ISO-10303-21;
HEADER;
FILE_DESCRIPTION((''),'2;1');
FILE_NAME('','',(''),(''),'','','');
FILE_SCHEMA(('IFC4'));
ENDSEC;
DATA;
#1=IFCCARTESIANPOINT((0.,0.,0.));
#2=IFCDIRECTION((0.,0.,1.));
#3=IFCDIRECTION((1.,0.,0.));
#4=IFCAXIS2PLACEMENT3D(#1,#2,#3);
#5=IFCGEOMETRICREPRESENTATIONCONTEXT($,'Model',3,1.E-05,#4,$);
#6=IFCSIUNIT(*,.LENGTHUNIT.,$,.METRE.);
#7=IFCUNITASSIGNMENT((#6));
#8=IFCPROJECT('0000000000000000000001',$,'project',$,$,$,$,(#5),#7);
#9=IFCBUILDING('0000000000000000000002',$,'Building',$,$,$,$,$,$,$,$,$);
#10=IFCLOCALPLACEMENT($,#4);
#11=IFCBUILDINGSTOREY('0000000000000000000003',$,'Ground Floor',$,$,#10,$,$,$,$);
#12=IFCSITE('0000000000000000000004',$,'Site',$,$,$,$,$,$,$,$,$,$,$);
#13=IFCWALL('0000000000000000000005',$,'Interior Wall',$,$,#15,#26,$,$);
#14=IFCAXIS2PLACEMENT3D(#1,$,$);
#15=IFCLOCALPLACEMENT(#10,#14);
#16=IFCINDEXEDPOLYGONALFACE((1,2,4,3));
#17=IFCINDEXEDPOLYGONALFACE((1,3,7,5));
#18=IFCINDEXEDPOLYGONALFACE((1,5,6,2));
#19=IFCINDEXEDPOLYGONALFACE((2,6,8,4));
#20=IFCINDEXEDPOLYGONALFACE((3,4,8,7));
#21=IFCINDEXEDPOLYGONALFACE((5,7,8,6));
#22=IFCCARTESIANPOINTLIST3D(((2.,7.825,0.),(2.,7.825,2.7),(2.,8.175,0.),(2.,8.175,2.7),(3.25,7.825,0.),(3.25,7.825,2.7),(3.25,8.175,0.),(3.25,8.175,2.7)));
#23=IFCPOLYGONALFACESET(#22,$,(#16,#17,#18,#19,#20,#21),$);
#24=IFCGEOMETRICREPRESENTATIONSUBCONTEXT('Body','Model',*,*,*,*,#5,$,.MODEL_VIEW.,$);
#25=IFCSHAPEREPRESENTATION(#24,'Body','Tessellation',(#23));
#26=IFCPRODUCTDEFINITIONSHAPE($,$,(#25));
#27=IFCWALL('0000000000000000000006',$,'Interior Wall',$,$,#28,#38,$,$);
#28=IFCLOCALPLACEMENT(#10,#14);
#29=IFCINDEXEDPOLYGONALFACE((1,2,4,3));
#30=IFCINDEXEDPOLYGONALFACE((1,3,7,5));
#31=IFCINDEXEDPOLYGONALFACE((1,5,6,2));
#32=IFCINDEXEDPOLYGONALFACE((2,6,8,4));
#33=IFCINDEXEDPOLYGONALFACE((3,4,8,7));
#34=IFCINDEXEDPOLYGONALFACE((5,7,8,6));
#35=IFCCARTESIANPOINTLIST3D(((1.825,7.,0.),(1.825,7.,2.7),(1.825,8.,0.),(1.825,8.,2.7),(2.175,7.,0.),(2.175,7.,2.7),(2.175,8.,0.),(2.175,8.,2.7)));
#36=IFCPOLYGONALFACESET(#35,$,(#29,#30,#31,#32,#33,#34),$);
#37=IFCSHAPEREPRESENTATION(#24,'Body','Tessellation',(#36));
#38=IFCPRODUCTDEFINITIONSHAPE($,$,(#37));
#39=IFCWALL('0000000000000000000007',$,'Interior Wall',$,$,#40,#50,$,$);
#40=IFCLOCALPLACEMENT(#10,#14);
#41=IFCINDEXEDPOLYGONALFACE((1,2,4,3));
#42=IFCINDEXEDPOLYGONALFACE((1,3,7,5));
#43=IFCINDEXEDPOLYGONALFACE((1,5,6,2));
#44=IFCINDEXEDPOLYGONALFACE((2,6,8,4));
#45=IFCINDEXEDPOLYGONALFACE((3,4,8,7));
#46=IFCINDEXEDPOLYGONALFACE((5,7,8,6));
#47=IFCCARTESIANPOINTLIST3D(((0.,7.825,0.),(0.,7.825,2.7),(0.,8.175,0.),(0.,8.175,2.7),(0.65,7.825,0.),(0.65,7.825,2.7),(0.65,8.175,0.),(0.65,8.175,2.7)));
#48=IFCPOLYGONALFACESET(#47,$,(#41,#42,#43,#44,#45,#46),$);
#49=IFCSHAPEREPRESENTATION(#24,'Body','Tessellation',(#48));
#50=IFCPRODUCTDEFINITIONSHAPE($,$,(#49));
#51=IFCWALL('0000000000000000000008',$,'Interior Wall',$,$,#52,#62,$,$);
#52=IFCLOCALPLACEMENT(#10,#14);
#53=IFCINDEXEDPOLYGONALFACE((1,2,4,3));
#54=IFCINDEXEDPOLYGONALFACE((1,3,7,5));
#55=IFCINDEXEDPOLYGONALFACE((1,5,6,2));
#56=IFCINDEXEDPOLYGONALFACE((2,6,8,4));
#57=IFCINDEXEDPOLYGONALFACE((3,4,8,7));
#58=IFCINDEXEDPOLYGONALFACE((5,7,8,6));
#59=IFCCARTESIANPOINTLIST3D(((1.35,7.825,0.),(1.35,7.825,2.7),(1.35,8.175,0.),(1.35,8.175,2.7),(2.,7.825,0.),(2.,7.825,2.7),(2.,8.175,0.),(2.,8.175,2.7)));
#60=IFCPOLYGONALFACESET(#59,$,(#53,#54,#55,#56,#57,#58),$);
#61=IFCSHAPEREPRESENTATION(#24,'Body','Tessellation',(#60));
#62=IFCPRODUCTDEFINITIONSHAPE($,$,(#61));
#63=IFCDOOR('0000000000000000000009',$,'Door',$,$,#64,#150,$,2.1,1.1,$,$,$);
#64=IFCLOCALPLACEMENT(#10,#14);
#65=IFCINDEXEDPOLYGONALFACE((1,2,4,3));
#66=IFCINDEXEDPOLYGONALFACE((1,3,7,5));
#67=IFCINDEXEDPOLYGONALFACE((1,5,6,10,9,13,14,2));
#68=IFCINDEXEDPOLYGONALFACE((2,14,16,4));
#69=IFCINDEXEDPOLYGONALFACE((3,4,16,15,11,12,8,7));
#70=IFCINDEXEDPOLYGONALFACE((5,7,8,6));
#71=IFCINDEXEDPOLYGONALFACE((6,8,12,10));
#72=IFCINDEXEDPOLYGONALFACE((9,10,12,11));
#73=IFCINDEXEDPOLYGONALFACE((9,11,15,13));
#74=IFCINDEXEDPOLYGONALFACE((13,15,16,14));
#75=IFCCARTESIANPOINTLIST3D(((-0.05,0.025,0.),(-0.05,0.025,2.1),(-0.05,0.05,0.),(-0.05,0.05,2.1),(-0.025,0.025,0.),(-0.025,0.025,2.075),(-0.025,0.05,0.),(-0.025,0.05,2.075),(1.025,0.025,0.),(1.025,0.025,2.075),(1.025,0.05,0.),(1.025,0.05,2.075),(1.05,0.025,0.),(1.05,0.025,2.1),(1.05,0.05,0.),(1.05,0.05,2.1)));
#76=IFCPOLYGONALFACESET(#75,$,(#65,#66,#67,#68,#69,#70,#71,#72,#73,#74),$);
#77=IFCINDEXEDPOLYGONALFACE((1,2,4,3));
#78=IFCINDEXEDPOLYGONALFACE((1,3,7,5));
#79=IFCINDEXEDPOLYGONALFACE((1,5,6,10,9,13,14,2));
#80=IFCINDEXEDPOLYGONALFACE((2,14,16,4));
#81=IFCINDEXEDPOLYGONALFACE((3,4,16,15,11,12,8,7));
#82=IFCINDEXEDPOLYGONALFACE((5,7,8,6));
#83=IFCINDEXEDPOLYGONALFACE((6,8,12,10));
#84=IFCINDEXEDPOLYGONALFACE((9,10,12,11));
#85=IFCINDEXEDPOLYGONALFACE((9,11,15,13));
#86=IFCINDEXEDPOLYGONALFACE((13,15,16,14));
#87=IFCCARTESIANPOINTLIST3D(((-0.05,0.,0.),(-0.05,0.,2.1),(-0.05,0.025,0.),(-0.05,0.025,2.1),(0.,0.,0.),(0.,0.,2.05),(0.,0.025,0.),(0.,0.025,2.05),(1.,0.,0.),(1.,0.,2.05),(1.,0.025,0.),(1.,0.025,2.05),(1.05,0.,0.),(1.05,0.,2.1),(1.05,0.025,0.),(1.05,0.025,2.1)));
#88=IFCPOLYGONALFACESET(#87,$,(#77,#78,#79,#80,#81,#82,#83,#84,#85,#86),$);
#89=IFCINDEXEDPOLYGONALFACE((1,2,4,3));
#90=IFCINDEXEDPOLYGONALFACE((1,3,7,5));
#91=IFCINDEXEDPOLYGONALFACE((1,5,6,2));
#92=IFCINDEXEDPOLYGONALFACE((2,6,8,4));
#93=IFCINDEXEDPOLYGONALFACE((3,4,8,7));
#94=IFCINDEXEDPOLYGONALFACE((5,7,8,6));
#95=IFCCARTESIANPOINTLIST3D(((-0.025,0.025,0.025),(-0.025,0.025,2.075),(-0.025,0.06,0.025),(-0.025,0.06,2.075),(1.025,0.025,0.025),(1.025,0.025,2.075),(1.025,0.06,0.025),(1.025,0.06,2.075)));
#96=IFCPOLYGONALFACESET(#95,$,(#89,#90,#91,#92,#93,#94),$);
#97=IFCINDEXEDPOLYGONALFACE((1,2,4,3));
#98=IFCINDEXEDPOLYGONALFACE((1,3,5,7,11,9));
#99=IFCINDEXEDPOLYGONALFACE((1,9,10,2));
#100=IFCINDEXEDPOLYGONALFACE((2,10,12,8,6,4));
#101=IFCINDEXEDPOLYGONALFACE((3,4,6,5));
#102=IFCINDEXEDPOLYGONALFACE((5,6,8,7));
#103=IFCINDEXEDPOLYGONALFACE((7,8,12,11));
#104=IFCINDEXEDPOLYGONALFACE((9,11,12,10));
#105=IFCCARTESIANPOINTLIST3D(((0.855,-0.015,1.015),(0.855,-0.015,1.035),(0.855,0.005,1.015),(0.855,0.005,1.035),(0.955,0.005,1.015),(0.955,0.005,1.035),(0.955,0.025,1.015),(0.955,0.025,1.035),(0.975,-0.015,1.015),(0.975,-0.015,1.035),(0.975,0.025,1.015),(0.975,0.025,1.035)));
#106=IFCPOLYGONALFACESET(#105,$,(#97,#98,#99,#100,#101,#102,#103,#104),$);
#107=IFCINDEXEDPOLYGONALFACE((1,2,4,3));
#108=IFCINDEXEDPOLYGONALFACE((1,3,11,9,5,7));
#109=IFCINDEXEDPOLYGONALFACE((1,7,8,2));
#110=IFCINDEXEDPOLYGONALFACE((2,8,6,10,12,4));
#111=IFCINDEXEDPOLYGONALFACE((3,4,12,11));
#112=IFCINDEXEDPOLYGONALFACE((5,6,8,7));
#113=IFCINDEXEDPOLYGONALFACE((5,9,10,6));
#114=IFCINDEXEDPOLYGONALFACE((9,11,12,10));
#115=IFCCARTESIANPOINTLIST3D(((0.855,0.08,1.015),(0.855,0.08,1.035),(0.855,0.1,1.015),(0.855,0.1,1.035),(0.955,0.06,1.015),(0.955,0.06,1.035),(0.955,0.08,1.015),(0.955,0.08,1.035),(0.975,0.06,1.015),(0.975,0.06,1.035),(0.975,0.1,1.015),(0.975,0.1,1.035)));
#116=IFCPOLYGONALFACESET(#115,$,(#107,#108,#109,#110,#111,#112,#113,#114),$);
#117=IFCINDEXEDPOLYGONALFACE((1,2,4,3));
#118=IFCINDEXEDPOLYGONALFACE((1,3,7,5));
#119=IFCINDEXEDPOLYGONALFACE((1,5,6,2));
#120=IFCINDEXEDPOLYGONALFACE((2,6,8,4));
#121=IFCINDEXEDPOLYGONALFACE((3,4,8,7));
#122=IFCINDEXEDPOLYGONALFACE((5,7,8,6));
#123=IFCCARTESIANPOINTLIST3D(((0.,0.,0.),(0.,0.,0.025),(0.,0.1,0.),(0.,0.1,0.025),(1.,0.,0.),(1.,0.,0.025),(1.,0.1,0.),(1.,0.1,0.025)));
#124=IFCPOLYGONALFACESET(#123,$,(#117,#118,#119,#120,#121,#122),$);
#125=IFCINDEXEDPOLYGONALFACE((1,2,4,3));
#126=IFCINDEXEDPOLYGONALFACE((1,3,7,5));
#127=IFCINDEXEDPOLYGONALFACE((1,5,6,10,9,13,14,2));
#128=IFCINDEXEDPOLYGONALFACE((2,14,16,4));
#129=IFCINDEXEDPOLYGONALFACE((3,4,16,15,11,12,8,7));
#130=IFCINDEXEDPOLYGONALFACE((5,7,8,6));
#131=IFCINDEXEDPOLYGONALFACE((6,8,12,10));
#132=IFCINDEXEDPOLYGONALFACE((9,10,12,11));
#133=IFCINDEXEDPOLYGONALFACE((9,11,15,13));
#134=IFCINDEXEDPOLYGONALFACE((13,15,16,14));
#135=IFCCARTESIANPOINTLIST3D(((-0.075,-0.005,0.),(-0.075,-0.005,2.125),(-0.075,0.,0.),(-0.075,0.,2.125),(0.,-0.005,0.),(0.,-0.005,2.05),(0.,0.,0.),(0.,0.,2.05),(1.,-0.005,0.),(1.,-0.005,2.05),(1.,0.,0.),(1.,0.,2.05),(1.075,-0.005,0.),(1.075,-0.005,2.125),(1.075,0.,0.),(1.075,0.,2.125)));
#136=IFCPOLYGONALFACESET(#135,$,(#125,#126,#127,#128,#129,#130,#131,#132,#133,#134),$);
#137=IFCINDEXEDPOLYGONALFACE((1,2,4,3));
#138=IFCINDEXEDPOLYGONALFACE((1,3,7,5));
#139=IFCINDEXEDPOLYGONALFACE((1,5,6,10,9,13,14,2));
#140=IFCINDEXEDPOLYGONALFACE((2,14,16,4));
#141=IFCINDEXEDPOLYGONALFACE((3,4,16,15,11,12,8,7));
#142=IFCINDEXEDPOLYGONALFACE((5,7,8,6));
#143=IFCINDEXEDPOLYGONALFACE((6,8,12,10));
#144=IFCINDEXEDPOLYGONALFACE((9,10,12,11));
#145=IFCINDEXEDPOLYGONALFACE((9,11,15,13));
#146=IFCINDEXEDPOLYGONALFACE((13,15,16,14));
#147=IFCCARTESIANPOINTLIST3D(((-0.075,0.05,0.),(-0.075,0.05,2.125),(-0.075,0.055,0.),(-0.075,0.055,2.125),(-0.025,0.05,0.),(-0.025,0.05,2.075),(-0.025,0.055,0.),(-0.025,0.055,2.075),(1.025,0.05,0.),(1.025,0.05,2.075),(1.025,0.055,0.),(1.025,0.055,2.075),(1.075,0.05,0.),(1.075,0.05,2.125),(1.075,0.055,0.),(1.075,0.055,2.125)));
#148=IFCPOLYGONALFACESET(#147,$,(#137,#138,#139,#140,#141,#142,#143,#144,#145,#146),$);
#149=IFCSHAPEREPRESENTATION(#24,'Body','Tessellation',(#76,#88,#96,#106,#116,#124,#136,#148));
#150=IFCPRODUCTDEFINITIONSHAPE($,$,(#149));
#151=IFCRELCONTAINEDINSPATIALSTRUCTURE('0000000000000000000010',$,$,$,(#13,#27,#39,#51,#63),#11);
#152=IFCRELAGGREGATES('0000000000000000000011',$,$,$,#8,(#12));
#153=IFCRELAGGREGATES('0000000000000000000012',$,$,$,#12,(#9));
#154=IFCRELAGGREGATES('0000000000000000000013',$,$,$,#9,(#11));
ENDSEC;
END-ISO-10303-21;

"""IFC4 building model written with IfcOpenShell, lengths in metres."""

from ifc_helpers import new_model, si_unit, frame, origin_with_axes, place, context, subcontext, project, spatial, line, indexed_curve, outline, extrude, element, save


model = new_model("IFC4")

# Units and contexts
model_context = context("Model", 3, precision=1e-05, world=origin_with_axes())
body_context = subcontext(model_context, "Body", "Model", "MODEL_VIEW")
ifc_project = project(units=[si_unit("LENGTHUNIT", "METRE")], contexts=[model_context])

# Site, building, storey
site = spatial("IfcSite", under=ifc_project, Name="Site")
building = spatial("IfcBuilding", under=site, Name="Building")
storey_placement = place(None, origin_with_axes())
storey = spatial("IfcBuildingStorey", under=building, at=storey_placement, Name="Ground Floor")

# Walls
wall_1_placement = place(storey_placement, frame((3.25, 8.0, 0.0), z_axis=(0.0, 0.0, 1.0), x_axis=(-1.0, 0.0, 0.0)))
element("IfcWall", 1, at=wall_1_placement, inside=storey, Name="Interior Wall", context=body_context, shape_type="SweptSolid", body=[
    extrude(outline(indexed_curve([(0.0, 0.0), (0.0, 0.35), (1.25, 0.35), (1.25, 0.0), (0.0, 0.0)], self_intersect=False)), frame((0.0, -0.175, 0.0), z_axis=(0.0, 0.0, 1.0), x_axis=(1.0, 0.0, 0.0)), (0.0, 0.0, 1.0), 2.7),
])
wall_2_placement = place(storey_placement, frame((2.0, 8.0, 0.0), z_axis=(0.0, 0.0, 1.0), x_axis=(0.0, -1.0, 0.0)))
element("IfcWall", 2, at=wall_2_placement, inside=storey, Name="Interior Wall", context=body_context, shape_type="SweptSolid", body=[
    extrude(outline(indexed_curve([(0.0, 0.0), (0.0, 0.35), (1.0, 0.35), (1.0, 0.0), (0.0, 0.0)], self_intersect=False)), frame((0.0, -0.175, 0.0), z_axis=(0.0, 0.0, 1.0), x_axis=(1.0, 0.0, 0.0)), (0.0, 0.0, 1.0), 2.7),
])
wall_3_placement = place(storey_placement, frame((0.0, 8.0, 0.0), z_axis=(0.0, 0.0, 1.0), x_axis=(1.0, 0.0, 0.0)))
element("IfcWall", 3, at=wall_3_placement, inside=storey, Name="Interior Wall", context=body_context, shape_type="SweptSolid", body=[
    extrude(outline(indexed_curve([(0.0, 0.0), (0.0, 0.35), (0.65, 0.35), (0.65, 0.0), (0.0, 0.0)], self_intersect=False)), frame((0.0, -0.175, 0.0), z_axis=(0.0, 0.0, 1.0), x_axis=(1.0, 0.0, 0.0)), (0.0, 0.0, 1.0), 2.7),
])
wall_4_placement = place(storey_placement, frame((1.35, 8.0, 0.0), z_axis=(0.0, 0.0, 1.0), x_axis=(1.0, 0.0, 0.0)))
element("IfcWall", 4, at=wall_4_placement, inside=storey, Name="Interior Wall", context=body_context, shape_type="SweptSolid", body=[
    extrude(outline(indexed_curve([(0.0, 0.0), (0.0, 0.35), (0.65, 0.35), (0.65, 0.0), (0.0, 0.0)], self_intersect=False)), frame((0.0, -0.175, 0.0), z_axis=(0.0, 0.0, 1.0), x_axis=(1.0, 0.0, 0.0)), (0.0, 0.0, 1.0), 2.7),
])

# Door
door_1_placement = place(storey_placement, frame((-0.05, 0.0, 0.0), z_axis=(0.0, 0.0, 1.0), x_axis=(1.0, 0.0, 0.0)))
element("IfcDoor", 5, at=door_1_placement, inside=storey, Name="Door", OverallHeight=2.1, OverallWidth=1.1, context=body_context, shape_type="SweptSolid", body=[
    extrude(outline(indexed_curve([(0.0, 0.0), (0.0, 2.1), (1.1, 2.1), (1.1, 0.0), (1.075, 0.0), (1.075, 2.075), (0.025, 2.075), (0.025, 0.0)], segments=[line(1, 2, 3, 4, 5, 6, 7, 8, 1)])), frame((0.0, 0.025, 0.0), z_axis=(0.0, -1.0, 0.0), x_axis=(1.0, 0.0, 0.0)), (0.0, 0.0, -1.0), 0.025),
    extrude(outline(indexed_curve([(0.0, 0.0), (0.0, 2.1), (1.1, 2.1), (1.1, 0.0), (1.05, 0.0), (1.05, 2.05), (0.05, 2.05), (0.05, 0.0)], segments=[line(1, 2, 3, 4, 5, 6, 7, 8, 1)])), frame((0.0, 0.0, 0.0), z_axis=(0.0, -1.0, 0.0), x_axis=(1.0, 0.0, 0.0)), (0.0, 0.0, -1.0), 0.025),
    extrude(outline(indexed_curve([(0.0, 0.0), (1.05, 0.0), (1.05, 0.035), (0.0, 0.035)], segments=[line(1, 2, 3, 4, 1)])), frame((0.025, 0.025, 0.025), z_axis=(0.0, 0.0, 1.0), x_axis=(1.0, 0.0, 0.0)), (0.0, 0.0, 1.0), 2.05),
    extrude(outline(indexed_curve([(0.0, 0.0), (0.0, -0.04), (-0.12, -0.04), (-0.12, -0.02), (-0.02, -0.02), (-0.02, 0.0)], segments=[line(1, 2, 3, 4, 5, 6, 1)])), frame((1.025, 0.025, 1.015), z_axis=(0.0, 0.0, 1.0), x_axis=(1.0, 0.0, 0.0)), (0.0, 0.0, 1.0), 0.02),
    extrude(outline(indexed_curve([(0.0, 0.0), (0.0, 0.04), (-0.12, 0.04), (-0.12, 0.02), (-0.02, 0.02), (-0.02, 0.0)], segments=[line(1, 2, 3, 4, 5, 6, 1)])), frame((1.025, 0.06, 1.015), z_axis=(0.0, 0.0, 1.0), x_axis=(1.0, 0.0, 0.0)), (0.0, 0.0, 1.0), 0.02),
    extrude(outline(indexed_curve([(0.0, 0.0), (1.0, 0.0), (1.0, 0.1), (0.0, 0.1)], segments=[line(1, 2, 3, 4, 1)])), frame((0.05, 0.0, 0.0), z_axis=(0.0, 0.0, 1.0), x_axis=(1.0, 0.0, 0.0)), (0.0, 0.0, 1.0), 0.025),
    extrude(outline(indexed_curve([(0.0, 0.0), (0.0, 2.125), (1.15, 2.125), (1.15, 0.0), (1.075, 0.0), (1.075, 2.05), (0.075, 2.05), (0.075, 0.0)], segments=[line(1, 2, 3, 4, 5, 6, 7, 8, 1)])), frame((-0.025, -0.005, 0.0), z_axis=(0.0, -1.0, 0.0), x_axis=(1.0, 0.0, 0.0)), (0.0, 0.0, -1.0), 0.005),
    extrude(outline(indexed_curve([(0.0, 0.0), (0.0, 2.125), (1.15, 2.125), (1.15, 0.0), (1.1, 0.0), (1.1, 2.075), (0.05, 2.075), (0.05, 0.0)], segments=[line(1, 2, 3, 4, 5, 6, 7, 8, 1)])), frame((-0.025, 0.05, 0.0), z_axis=(0.0, -1.0, 0.0), x_axis=(1.0, 0.0, 0.0)), (0.0, 0.0, -1.0), 0.005),
])

save(model, "model.ifc")
